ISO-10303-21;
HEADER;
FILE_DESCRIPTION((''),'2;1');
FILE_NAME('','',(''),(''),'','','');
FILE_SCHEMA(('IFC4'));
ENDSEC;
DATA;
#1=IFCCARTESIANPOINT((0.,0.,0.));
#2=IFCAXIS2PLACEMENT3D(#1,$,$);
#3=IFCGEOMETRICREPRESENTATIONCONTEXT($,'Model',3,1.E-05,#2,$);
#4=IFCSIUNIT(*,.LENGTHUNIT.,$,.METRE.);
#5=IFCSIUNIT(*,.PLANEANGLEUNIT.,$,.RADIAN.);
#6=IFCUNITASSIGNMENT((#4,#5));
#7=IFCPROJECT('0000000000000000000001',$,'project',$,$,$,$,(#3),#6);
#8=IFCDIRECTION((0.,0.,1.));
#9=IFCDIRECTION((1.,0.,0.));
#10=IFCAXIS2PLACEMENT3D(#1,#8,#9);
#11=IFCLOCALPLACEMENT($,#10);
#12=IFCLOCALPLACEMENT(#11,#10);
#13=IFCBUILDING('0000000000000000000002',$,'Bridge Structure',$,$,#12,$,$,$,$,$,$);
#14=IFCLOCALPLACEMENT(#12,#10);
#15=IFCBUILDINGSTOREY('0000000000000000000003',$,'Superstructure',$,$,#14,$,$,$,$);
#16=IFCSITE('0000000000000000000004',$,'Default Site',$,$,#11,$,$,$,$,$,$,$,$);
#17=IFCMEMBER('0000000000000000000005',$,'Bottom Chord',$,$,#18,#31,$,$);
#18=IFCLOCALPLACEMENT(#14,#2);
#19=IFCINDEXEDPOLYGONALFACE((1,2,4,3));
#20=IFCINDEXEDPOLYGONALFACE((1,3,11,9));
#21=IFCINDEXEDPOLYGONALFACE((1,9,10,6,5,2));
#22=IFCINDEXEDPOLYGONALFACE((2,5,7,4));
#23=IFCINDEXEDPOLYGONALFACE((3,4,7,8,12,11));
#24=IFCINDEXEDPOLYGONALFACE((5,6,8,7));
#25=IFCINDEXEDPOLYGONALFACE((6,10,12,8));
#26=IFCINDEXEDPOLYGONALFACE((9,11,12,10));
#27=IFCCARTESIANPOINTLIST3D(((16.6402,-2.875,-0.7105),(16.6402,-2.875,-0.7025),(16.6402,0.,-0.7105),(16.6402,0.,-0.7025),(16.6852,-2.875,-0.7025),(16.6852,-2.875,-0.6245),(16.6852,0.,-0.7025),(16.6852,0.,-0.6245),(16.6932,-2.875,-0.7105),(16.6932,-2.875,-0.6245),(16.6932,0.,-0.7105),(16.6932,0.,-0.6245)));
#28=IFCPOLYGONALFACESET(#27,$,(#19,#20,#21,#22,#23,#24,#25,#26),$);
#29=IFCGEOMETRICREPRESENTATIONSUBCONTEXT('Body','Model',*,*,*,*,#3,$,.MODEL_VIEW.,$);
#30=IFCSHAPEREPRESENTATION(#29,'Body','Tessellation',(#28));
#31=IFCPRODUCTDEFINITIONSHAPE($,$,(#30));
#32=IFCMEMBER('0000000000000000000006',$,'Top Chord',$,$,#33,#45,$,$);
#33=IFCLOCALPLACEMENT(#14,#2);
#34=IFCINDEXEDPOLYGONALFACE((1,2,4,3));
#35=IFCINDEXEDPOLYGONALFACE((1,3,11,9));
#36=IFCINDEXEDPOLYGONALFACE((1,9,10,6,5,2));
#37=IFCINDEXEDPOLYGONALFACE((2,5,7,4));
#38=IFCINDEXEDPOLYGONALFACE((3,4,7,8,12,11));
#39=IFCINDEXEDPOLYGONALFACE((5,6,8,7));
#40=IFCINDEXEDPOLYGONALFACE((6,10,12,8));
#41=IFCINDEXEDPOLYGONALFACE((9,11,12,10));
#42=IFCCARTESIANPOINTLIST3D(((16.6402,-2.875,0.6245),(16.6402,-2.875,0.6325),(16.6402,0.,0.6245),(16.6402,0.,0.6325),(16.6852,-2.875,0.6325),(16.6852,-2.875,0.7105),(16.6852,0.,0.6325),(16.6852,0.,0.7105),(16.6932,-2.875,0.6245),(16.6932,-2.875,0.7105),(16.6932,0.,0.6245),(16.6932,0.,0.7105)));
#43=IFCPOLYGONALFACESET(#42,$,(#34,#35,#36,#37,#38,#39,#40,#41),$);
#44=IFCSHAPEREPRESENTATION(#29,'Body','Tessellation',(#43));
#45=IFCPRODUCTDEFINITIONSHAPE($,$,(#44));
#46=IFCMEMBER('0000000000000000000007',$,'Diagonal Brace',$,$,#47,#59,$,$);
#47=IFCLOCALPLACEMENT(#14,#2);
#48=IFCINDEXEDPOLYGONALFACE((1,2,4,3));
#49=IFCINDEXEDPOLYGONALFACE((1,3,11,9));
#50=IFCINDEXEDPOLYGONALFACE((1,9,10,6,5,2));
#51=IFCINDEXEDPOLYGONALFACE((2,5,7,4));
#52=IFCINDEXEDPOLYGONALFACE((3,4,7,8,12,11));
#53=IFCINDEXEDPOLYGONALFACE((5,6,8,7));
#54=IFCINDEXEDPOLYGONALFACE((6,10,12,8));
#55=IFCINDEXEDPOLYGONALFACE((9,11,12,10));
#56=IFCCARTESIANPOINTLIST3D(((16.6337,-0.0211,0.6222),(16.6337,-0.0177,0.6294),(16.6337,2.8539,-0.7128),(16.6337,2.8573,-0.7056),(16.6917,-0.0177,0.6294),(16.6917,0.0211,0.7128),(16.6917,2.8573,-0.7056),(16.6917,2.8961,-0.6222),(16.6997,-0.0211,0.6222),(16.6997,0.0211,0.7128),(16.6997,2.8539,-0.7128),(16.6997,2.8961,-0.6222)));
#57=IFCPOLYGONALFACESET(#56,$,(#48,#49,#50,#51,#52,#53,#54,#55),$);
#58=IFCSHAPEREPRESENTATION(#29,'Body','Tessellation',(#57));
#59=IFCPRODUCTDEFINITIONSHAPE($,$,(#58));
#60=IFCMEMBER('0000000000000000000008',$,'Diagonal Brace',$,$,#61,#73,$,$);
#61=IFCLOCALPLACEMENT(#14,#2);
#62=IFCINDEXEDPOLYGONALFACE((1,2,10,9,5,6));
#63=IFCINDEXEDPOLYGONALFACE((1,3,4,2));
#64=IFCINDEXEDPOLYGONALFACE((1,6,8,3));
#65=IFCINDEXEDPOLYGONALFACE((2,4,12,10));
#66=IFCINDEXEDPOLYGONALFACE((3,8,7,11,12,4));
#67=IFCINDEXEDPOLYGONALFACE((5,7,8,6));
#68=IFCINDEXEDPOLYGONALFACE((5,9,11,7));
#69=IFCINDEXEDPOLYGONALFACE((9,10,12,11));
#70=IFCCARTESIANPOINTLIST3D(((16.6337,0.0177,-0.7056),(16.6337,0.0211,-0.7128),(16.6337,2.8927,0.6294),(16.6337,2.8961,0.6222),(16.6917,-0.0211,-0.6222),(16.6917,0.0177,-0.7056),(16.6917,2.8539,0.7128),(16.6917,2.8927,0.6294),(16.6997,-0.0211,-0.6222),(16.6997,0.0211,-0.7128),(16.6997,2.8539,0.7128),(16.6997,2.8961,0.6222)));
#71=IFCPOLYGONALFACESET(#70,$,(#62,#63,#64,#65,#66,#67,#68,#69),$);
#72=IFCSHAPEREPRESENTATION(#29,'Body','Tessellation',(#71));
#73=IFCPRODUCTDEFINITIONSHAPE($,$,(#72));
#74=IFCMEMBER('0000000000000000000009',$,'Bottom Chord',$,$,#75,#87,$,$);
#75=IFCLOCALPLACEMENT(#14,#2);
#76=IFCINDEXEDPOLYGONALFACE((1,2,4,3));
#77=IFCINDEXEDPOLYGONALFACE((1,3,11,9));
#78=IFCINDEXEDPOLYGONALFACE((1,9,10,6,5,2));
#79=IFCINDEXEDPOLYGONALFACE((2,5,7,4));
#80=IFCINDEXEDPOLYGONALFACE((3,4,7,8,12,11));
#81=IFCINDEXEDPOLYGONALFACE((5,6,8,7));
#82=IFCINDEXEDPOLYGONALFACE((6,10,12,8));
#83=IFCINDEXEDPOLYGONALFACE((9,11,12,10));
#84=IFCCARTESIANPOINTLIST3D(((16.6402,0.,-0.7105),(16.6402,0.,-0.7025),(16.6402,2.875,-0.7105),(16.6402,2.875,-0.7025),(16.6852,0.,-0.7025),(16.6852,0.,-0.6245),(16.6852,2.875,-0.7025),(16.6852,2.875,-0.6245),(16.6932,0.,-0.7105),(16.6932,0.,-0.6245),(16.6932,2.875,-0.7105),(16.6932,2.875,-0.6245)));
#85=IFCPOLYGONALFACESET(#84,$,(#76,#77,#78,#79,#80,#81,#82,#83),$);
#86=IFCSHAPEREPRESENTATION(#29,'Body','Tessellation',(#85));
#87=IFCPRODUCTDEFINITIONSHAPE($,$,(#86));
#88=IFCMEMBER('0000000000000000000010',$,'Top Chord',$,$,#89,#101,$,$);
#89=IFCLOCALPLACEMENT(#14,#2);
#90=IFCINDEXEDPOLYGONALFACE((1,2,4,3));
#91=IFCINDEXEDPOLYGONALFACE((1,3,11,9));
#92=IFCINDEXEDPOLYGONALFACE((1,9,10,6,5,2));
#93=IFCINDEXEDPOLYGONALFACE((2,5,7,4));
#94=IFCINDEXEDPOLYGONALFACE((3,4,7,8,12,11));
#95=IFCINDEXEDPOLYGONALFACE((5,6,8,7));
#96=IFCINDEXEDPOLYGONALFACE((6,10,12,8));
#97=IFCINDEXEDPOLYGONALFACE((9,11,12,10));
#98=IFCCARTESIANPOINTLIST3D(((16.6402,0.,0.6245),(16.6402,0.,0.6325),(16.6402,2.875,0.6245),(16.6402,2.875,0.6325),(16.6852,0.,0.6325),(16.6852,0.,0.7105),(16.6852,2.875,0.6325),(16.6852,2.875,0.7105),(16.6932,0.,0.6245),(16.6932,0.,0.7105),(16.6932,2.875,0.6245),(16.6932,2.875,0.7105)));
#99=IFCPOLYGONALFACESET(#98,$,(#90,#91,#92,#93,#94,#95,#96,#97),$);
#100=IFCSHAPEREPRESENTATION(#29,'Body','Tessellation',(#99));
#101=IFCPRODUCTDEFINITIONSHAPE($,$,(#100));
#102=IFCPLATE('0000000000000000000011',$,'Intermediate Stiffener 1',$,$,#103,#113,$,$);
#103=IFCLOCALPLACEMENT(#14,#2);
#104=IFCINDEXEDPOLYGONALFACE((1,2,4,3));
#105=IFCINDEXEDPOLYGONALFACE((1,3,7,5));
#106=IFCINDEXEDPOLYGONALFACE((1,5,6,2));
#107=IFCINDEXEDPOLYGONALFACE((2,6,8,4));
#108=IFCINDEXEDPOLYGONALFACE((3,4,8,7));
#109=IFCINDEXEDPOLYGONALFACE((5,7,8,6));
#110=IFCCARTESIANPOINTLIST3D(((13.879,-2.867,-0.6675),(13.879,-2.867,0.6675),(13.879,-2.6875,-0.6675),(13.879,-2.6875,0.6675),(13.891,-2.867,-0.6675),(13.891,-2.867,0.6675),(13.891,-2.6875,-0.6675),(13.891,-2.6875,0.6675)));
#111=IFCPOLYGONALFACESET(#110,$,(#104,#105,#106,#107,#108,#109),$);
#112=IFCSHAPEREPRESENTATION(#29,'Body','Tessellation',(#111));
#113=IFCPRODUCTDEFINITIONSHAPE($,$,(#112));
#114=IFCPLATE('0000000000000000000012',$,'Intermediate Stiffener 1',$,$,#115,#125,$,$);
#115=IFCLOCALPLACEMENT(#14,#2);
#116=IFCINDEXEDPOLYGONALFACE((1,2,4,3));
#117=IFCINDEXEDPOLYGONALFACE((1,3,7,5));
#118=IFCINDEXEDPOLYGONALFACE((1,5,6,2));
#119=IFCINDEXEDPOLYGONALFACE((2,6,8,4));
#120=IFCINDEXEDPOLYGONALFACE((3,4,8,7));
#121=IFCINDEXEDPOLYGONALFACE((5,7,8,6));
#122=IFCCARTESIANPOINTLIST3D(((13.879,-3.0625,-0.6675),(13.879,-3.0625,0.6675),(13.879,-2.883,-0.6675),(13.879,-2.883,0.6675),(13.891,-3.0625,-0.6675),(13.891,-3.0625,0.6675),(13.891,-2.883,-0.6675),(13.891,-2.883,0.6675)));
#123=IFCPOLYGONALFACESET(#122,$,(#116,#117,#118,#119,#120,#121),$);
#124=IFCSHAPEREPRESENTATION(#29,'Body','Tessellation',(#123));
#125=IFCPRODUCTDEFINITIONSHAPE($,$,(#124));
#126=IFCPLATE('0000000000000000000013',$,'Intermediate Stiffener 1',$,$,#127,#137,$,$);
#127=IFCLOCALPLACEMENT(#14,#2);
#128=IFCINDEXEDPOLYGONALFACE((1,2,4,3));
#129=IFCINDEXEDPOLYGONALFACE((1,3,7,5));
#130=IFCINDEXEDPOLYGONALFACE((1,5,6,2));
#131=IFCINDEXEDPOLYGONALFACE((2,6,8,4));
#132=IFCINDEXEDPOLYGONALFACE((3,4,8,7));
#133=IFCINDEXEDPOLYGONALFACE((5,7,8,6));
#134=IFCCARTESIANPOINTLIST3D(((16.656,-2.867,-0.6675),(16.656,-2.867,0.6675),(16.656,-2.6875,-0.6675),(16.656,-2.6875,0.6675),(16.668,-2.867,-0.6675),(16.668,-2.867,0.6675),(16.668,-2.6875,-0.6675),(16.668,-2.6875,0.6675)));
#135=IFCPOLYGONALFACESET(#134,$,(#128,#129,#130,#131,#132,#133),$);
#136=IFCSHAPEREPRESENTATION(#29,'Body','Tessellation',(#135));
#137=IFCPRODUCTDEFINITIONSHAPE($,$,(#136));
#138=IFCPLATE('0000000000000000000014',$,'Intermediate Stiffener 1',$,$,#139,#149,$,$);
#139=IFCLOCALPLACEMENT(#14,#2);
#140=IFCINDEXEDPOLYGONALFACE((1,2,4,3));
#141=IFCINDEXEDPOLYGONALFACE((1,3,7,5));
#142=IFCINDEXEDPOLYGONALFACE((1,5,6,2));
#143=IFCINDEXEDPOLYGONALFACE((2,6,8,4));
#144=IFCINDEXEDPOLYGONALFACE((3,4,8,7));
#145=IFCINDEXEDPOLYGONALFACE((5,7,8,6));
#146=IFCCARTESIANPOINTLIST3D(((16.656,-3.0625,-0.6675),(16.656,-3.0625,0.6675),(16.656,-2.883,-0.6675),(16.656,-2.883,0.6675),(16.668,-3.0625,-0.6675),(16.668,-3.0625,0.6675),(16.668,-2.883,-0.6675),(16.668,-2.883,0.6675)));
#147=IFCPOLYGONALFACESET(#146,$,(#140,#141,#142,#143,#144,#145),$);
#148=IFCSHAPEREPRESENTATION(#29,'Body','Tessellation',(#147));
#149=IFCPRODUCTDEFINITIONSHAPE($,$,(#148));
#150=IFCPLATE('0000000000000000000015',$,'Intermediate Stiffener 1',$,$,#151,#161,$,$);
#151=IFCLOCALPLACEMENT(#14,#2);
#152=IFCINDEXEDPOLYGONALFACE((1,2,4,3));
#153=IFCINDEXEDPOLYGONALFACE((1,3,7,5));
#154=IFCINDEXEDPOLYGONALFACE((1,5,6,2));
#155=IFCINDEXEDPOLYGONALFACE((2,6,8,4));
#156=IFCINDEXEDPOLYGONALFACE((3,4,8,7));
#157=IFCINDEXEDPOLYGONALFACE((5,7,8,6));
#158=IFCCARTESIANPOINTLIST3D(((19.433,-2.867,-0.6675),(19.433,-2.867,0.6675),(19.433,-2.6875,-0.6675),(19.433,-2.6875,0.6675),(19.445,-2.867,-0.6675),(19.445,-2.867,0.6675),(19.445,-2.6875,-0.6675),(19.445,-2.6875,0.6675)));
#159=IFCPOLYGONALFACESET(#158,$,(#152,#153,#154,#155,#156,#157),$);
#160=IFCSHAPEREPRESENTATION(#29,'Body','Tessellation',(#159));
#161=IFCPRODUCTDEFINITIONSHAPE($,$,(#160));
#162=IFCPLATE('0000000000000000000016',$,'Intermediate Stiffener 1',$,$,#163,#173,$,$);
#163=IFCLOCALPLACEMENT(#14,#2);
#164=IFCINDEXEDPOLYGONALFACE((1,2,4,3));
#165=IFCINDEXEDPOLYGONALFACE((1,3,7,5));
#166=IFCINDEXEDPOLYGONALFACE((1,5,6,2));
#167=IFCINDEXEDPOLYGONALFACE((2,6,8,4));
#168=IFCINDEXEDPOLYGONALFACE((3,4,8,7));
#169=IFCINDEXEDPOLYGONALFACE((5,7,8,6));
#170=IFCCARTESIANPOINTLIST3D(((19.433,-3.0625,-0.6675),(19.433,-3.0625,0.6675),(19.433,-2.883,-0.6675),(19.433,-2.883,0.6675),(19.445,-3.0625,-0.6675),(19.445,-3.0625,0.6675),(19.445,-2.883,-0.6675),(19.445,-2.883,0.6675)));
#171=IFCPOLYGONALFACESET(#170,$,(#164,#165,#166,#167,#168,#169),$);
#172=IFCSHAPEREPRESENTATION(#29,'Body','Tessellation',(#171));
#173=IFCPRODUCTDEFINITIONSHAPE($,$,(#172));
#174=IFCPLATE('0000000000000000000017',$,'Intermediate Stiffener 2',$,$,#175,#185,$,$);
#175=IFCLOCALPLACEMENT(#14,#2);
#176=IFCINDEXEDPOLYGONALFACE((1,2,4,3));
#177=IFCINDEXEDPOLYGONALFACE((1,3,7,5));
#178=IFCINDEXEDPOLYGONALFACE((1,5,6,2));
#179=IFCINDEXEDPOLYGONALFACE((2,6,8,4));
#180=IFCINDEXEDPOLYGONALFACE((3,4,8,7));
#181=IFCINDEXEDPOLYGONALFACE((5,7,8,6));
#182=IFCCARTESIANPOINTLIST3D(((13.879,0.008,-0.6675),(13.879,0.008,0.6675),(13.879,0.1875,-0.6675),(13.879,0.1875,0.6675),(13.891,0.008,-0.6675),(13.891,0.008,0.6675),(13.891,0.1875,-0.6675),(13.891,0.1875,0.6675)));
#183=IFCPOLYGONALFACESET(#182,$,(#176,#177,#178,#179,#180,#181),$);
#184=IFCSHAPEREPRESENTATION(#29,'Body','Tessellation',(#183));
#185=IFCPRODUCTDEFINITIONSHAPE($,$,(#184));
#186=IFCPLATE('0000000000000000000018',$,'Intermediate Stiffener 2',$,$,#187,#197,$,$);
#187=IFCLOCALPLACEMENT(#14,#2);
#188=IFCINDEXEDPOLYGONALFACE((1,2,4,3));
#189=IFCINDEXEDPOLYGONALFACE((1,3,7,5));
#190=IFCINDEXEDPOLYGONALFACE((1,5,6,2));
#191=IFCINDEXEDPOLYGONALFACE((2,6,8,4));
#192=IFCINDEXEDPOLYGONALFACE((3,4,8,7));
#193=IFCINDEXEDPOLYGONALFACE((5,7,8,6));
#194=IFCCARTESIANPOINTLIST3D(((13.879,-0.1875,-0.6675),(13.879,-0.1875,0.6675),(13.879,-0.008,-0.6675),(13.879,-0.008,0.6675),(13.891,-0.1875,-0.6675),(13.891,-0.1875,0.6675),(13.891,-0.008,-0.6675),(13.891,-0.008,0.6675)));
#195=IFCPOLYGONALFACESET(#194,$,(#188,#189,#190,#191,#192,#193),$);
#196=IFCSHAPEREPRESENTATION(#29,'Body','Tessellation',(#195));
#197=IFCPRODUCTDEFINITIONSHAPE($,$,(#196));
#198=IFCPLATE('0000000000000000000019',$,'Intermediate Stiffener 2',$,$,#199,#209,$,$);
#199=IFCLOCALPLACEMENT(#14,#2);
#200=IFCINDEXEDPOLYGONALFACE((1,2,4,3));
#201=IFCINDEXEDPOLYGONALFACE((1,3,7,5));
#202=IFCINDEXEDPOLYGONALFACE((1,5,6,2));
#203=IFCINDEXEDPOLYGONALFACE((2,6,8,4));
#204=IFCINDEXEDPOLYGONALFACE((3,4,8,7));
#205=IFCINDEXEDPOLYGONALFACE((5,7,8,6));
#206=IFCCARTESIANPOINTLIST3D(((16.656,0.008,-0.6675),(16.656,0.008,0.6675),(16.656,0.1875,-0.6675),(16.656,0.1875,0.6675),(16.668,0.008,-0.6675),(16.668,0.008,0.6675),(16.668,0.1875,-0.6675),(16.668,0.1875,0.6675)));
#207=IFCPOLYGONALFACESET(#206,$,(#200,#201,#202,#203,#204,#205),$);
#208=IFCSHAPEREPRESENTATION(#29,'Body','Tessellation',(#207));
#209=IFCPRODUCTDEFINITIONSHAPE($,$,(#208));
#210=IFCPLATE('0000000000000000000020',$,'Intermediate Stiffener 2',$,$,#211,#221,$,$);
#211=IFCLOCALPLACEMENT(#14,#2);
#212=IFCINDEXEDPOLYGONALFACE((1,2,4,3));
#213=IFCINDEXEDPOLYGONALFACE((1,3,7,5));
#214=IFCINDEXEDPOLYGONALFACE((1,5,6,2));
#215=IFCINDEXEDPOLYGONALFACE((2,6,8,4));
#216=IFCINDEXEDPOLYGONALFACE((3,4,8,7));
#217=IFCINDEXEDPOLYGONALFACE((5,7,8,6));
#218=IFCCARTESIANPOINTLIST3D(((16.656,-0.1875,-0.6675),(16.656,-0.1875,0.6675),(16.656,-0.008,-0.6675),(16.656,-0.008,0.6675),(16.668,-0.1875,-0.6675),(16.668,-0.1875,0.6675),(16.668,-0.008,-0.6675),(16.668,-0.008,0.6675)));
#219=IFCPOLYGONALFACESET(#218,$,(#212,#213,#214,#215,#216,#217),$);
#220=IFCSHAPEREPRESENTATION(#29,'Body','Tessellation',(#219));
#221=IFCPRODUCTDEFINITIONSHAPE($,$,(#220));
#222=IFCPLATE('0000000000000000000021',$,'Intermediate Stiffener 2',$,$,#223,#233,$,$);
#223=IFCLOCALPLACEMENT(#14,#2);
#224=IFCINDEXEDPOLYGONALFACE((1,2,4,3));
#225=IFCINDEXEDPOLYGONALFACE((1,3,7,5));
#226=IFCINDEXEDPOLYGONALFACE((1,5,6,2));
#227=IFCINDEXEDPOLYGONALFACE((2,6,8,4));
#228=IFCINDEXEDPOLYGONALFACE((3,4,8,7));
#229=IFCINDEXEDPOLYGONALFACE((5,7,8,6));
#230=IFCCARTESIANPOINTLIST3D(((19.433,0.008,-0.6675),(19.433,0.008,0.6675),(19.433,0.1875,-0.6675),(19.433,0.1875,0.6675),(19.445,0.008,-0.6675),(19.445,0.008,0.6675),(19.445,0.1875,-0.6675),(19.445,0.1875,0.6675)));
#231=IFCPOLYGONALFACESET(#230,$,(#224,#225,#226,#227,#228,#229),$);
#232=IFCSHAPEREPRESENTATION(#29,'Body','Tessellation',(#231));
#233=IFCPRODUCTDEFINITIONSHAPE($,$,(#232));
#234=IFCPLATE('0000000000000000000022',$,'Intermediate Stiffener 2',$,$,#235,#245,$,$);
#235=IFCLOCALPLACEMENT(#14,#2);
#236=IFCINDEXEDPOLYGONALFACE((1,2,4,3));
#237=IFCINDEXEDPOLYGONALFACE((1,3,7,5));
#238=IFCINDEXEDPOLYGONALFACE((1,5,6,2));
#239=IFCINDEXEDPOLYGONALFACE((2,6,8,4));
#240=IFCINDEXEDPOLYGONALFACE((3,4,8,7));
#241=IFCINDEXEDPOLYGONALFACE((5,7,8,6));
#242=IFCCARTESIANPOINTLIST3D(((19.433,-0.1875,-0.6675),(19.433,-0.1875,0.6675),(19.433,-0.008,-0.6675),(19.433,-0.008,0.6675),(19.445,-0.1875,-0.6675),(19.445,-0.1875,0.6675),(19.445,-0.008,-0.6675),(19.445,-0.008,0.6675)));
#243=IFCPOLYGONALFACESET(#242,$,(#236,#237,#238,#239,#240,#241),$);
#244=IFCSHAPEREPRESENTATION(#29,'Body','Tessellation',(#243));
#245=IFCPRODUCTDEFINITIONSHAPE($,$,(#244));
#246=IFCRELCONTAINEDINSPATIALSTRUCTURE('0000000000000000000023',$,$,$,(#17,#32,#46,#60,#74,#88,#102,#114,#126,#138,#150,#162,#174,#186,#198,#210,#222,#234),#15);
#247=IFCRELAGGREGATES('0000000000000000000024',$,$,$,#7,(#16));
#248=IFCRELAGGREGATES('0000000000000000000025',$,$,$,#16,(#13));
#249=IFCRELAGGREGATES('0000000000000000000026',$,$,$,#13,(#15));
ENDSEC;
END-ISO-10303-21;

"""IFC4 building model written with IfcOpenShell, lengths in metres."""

from ifc_helpers import new_model, si_unit, frame, origin, origin_with_axes, origin_2d_with_axis, place, context, subcontext, project, spatial, rectangle, l_section, extrude, element, save


model = new_model("IFC4")

# Units and contexts
model_context = context("Model", 3, precision=1e-05, world=origin())
body_context = subcontext(model_context, "Body", "Model", "MODEL_VIEW")
ifc_project = project(units=[si_unit("LENGTHUNIT", "METRE"), si_unit("PLANEANGLEUNIT", "RADIAN")], contexts=[model_context])

# Site, building, storey
site_placement = place(None, origin_with_axes())
site = spatial("IfcSite", under=ifc_project, at=site_placement, Name="Default Site")
building_placement = place(site_placement, origin_with_axes())
building = spatial("IfcBuilding", under=site, at=building_placement, Name="Bridge Structure")
storey_placement = place(building_placement, origin_with_axes())
storey = spatial("IfcBuildingStorey", under=building, at=storey_placement, Name="Superstructure")

# Members
for number, where, z_axis, x_axis, name in (
    (1, (16.6667, -2.875, -0.6675), (0.0, 1.0, 0.0), (-1.0, 0.0, 0.0), "Bottom Chord"),
    (2, (16.6667, -2.875, 0.6675), (0.0, 1.0, 0.0), (-1.0, 0.0, 0.0), "Top Chord"),
):
    element("IfcMember", number, at=place(storey_placement, frame(where, z_axis=z_axis, x_axis=x_axis)), inside=storey, Name=name, context=body_context, shape_type="SweptSolid", body=[
        extrude(l_section(Depth=0.086, Width=0.053, Thickness=0.008, at=origin_2d_with_axis()), origin_with_axes(), (0.0, 0.0, 1.0), 2.875),
    ])
for number, where, z_axis, x_axis, name in (
    (3, (16.6667, 0.0, 0.6675), (0.0, 0.906987, -0.421158), (-1.0, 0.0, 0.0), "Diagonal Brace"),
    (4, (16.6667, 0.0, -0.6675), (0.0, 0.906987, 0.421158), (-1.0, 0.0, 0.0), "Diagonal Brace"),
):
    element("IfcMember", number, at=place(storey_placement, frame(where, z_axis=z_axis, x_axis=x_axis)), inside=storey, Name=name, context=body_context, shape_type="SweptSolid", body=[
        extrude(l_section(Depth=0.1, Width=0.066, Thickness=0.008, at=origin_2d_with_axis()), origin_with_axes(), (0.0, 0.0, 1.0), 3.1698),
    ])
for number, where, z_axis, x_axis, name in (
    (5, (16.6667, 0.0, -0.6675), (0.0, 1.0, 0.0), (-1.0, 0.0, 0.0), "Bottom Chord"),
    (6, (16.6667, 0.0, 0.6675), (0.0, 1.0, 0.0), (-1.0, 0.0, 0.0), "Top Chord"),
):
    element("IfcMember", number, at=place(storey_placement, frame(where, z_axis=z_axis, x_axis=x_axis)), inside=storey, Name=name, context=body_context, shape_type="SweptSolid", body=[
        extrude(l_section(Depth=0.086, Width=0.053, Thickness=0.008, at=origin_2d_with_axis()), origin_with_axes(), (0.0, 0.0, 1.0), 2.875),
    ])

# Plates
for number, where, z_axis, x_axis, name in (
    (7, (13.885, -2.7772, -0.6675), (0.0, 0.0, 1.0), (1.0, 0.0, 0.0), "Intermediate Stiffener 1"),
    (8, (13.885, -2.9728, -0.6675), (0.0, 0.0, 1.0), (1.0, 0.0, 0.0), "Intermediate Stiffener 1"),
    (9, (16.662, -2.7772, -0.6675), (0.0, 0.0, 1.0), (1.0, 0.0, 0.0), "Intermediate Stiffener 1"),
    (10, (16.662, -2.9728, -0.6675), (0.0, 0.0, 1.0), (1.0, 0.0, 0.0), "Intermediate Stiffener 1"),
    (11, (19.439, -2.7772, -0.6675), (0.0, 0.0, 1.0), (1.0, 0.0, 0.0), "Intermediate Stiffener 1"),
    (12, (19.439, -2.9728, -0.6675), (0.0, 0.0, 1.0), (1.0, 0.0, 0.0), "Intermediate Stiffener 1"),
    (13, (13.885, 0.0978, -0.6675), (0.0, 0.0, 1.0), (1.0, 0.0, 0.0), "Intermediate Stiffener 2"),
    (14, (13.885, -0.0978, -0.6675), (0.0, 0.0, 1.0), (1.0, 0.0, 0.0), "Intermediate Stiffener 2"),
    (15, (16.662, 0.0978, -0.6675), (0.0, 0.0, 1.0), (1.0, 0.0, 0.0), "Intermediate Stiffener 2"),
    (16, (16.662, -0.0978, -0.6675), (0.0, 0.0, 1.0), (1.0, 0.0, 0.0), "Intermediate Stiffener 2"),
    (17, (19.439, 0.0978, -0.6675), (0.0, 0.0, 1.0), (1.0, 0.0, 0.0), "Intermediate Stiffener 2"),
    (18, (19.439, -0.0978, -0.6675), (0.0, 0.0, 1.0), (1.0, 0.0, 0.0), "Intermediate Stiffener 2"),
):
    element("IfcPlate", number, at=place(storey_placement, frame(where, z_axis=z_axis, x_axis=x_axis)), inside=storey, Name=name, context=body_context, shape_type="SweptSolid", body=[
        extrude(rectangle(XDim=0.012, YDim=0.1795, at=origin_2d_with_axis()), origin_with_axes(), (0.0, 0.0, 1.0), 1.335),
    ])

save(model, "model.ifc")
